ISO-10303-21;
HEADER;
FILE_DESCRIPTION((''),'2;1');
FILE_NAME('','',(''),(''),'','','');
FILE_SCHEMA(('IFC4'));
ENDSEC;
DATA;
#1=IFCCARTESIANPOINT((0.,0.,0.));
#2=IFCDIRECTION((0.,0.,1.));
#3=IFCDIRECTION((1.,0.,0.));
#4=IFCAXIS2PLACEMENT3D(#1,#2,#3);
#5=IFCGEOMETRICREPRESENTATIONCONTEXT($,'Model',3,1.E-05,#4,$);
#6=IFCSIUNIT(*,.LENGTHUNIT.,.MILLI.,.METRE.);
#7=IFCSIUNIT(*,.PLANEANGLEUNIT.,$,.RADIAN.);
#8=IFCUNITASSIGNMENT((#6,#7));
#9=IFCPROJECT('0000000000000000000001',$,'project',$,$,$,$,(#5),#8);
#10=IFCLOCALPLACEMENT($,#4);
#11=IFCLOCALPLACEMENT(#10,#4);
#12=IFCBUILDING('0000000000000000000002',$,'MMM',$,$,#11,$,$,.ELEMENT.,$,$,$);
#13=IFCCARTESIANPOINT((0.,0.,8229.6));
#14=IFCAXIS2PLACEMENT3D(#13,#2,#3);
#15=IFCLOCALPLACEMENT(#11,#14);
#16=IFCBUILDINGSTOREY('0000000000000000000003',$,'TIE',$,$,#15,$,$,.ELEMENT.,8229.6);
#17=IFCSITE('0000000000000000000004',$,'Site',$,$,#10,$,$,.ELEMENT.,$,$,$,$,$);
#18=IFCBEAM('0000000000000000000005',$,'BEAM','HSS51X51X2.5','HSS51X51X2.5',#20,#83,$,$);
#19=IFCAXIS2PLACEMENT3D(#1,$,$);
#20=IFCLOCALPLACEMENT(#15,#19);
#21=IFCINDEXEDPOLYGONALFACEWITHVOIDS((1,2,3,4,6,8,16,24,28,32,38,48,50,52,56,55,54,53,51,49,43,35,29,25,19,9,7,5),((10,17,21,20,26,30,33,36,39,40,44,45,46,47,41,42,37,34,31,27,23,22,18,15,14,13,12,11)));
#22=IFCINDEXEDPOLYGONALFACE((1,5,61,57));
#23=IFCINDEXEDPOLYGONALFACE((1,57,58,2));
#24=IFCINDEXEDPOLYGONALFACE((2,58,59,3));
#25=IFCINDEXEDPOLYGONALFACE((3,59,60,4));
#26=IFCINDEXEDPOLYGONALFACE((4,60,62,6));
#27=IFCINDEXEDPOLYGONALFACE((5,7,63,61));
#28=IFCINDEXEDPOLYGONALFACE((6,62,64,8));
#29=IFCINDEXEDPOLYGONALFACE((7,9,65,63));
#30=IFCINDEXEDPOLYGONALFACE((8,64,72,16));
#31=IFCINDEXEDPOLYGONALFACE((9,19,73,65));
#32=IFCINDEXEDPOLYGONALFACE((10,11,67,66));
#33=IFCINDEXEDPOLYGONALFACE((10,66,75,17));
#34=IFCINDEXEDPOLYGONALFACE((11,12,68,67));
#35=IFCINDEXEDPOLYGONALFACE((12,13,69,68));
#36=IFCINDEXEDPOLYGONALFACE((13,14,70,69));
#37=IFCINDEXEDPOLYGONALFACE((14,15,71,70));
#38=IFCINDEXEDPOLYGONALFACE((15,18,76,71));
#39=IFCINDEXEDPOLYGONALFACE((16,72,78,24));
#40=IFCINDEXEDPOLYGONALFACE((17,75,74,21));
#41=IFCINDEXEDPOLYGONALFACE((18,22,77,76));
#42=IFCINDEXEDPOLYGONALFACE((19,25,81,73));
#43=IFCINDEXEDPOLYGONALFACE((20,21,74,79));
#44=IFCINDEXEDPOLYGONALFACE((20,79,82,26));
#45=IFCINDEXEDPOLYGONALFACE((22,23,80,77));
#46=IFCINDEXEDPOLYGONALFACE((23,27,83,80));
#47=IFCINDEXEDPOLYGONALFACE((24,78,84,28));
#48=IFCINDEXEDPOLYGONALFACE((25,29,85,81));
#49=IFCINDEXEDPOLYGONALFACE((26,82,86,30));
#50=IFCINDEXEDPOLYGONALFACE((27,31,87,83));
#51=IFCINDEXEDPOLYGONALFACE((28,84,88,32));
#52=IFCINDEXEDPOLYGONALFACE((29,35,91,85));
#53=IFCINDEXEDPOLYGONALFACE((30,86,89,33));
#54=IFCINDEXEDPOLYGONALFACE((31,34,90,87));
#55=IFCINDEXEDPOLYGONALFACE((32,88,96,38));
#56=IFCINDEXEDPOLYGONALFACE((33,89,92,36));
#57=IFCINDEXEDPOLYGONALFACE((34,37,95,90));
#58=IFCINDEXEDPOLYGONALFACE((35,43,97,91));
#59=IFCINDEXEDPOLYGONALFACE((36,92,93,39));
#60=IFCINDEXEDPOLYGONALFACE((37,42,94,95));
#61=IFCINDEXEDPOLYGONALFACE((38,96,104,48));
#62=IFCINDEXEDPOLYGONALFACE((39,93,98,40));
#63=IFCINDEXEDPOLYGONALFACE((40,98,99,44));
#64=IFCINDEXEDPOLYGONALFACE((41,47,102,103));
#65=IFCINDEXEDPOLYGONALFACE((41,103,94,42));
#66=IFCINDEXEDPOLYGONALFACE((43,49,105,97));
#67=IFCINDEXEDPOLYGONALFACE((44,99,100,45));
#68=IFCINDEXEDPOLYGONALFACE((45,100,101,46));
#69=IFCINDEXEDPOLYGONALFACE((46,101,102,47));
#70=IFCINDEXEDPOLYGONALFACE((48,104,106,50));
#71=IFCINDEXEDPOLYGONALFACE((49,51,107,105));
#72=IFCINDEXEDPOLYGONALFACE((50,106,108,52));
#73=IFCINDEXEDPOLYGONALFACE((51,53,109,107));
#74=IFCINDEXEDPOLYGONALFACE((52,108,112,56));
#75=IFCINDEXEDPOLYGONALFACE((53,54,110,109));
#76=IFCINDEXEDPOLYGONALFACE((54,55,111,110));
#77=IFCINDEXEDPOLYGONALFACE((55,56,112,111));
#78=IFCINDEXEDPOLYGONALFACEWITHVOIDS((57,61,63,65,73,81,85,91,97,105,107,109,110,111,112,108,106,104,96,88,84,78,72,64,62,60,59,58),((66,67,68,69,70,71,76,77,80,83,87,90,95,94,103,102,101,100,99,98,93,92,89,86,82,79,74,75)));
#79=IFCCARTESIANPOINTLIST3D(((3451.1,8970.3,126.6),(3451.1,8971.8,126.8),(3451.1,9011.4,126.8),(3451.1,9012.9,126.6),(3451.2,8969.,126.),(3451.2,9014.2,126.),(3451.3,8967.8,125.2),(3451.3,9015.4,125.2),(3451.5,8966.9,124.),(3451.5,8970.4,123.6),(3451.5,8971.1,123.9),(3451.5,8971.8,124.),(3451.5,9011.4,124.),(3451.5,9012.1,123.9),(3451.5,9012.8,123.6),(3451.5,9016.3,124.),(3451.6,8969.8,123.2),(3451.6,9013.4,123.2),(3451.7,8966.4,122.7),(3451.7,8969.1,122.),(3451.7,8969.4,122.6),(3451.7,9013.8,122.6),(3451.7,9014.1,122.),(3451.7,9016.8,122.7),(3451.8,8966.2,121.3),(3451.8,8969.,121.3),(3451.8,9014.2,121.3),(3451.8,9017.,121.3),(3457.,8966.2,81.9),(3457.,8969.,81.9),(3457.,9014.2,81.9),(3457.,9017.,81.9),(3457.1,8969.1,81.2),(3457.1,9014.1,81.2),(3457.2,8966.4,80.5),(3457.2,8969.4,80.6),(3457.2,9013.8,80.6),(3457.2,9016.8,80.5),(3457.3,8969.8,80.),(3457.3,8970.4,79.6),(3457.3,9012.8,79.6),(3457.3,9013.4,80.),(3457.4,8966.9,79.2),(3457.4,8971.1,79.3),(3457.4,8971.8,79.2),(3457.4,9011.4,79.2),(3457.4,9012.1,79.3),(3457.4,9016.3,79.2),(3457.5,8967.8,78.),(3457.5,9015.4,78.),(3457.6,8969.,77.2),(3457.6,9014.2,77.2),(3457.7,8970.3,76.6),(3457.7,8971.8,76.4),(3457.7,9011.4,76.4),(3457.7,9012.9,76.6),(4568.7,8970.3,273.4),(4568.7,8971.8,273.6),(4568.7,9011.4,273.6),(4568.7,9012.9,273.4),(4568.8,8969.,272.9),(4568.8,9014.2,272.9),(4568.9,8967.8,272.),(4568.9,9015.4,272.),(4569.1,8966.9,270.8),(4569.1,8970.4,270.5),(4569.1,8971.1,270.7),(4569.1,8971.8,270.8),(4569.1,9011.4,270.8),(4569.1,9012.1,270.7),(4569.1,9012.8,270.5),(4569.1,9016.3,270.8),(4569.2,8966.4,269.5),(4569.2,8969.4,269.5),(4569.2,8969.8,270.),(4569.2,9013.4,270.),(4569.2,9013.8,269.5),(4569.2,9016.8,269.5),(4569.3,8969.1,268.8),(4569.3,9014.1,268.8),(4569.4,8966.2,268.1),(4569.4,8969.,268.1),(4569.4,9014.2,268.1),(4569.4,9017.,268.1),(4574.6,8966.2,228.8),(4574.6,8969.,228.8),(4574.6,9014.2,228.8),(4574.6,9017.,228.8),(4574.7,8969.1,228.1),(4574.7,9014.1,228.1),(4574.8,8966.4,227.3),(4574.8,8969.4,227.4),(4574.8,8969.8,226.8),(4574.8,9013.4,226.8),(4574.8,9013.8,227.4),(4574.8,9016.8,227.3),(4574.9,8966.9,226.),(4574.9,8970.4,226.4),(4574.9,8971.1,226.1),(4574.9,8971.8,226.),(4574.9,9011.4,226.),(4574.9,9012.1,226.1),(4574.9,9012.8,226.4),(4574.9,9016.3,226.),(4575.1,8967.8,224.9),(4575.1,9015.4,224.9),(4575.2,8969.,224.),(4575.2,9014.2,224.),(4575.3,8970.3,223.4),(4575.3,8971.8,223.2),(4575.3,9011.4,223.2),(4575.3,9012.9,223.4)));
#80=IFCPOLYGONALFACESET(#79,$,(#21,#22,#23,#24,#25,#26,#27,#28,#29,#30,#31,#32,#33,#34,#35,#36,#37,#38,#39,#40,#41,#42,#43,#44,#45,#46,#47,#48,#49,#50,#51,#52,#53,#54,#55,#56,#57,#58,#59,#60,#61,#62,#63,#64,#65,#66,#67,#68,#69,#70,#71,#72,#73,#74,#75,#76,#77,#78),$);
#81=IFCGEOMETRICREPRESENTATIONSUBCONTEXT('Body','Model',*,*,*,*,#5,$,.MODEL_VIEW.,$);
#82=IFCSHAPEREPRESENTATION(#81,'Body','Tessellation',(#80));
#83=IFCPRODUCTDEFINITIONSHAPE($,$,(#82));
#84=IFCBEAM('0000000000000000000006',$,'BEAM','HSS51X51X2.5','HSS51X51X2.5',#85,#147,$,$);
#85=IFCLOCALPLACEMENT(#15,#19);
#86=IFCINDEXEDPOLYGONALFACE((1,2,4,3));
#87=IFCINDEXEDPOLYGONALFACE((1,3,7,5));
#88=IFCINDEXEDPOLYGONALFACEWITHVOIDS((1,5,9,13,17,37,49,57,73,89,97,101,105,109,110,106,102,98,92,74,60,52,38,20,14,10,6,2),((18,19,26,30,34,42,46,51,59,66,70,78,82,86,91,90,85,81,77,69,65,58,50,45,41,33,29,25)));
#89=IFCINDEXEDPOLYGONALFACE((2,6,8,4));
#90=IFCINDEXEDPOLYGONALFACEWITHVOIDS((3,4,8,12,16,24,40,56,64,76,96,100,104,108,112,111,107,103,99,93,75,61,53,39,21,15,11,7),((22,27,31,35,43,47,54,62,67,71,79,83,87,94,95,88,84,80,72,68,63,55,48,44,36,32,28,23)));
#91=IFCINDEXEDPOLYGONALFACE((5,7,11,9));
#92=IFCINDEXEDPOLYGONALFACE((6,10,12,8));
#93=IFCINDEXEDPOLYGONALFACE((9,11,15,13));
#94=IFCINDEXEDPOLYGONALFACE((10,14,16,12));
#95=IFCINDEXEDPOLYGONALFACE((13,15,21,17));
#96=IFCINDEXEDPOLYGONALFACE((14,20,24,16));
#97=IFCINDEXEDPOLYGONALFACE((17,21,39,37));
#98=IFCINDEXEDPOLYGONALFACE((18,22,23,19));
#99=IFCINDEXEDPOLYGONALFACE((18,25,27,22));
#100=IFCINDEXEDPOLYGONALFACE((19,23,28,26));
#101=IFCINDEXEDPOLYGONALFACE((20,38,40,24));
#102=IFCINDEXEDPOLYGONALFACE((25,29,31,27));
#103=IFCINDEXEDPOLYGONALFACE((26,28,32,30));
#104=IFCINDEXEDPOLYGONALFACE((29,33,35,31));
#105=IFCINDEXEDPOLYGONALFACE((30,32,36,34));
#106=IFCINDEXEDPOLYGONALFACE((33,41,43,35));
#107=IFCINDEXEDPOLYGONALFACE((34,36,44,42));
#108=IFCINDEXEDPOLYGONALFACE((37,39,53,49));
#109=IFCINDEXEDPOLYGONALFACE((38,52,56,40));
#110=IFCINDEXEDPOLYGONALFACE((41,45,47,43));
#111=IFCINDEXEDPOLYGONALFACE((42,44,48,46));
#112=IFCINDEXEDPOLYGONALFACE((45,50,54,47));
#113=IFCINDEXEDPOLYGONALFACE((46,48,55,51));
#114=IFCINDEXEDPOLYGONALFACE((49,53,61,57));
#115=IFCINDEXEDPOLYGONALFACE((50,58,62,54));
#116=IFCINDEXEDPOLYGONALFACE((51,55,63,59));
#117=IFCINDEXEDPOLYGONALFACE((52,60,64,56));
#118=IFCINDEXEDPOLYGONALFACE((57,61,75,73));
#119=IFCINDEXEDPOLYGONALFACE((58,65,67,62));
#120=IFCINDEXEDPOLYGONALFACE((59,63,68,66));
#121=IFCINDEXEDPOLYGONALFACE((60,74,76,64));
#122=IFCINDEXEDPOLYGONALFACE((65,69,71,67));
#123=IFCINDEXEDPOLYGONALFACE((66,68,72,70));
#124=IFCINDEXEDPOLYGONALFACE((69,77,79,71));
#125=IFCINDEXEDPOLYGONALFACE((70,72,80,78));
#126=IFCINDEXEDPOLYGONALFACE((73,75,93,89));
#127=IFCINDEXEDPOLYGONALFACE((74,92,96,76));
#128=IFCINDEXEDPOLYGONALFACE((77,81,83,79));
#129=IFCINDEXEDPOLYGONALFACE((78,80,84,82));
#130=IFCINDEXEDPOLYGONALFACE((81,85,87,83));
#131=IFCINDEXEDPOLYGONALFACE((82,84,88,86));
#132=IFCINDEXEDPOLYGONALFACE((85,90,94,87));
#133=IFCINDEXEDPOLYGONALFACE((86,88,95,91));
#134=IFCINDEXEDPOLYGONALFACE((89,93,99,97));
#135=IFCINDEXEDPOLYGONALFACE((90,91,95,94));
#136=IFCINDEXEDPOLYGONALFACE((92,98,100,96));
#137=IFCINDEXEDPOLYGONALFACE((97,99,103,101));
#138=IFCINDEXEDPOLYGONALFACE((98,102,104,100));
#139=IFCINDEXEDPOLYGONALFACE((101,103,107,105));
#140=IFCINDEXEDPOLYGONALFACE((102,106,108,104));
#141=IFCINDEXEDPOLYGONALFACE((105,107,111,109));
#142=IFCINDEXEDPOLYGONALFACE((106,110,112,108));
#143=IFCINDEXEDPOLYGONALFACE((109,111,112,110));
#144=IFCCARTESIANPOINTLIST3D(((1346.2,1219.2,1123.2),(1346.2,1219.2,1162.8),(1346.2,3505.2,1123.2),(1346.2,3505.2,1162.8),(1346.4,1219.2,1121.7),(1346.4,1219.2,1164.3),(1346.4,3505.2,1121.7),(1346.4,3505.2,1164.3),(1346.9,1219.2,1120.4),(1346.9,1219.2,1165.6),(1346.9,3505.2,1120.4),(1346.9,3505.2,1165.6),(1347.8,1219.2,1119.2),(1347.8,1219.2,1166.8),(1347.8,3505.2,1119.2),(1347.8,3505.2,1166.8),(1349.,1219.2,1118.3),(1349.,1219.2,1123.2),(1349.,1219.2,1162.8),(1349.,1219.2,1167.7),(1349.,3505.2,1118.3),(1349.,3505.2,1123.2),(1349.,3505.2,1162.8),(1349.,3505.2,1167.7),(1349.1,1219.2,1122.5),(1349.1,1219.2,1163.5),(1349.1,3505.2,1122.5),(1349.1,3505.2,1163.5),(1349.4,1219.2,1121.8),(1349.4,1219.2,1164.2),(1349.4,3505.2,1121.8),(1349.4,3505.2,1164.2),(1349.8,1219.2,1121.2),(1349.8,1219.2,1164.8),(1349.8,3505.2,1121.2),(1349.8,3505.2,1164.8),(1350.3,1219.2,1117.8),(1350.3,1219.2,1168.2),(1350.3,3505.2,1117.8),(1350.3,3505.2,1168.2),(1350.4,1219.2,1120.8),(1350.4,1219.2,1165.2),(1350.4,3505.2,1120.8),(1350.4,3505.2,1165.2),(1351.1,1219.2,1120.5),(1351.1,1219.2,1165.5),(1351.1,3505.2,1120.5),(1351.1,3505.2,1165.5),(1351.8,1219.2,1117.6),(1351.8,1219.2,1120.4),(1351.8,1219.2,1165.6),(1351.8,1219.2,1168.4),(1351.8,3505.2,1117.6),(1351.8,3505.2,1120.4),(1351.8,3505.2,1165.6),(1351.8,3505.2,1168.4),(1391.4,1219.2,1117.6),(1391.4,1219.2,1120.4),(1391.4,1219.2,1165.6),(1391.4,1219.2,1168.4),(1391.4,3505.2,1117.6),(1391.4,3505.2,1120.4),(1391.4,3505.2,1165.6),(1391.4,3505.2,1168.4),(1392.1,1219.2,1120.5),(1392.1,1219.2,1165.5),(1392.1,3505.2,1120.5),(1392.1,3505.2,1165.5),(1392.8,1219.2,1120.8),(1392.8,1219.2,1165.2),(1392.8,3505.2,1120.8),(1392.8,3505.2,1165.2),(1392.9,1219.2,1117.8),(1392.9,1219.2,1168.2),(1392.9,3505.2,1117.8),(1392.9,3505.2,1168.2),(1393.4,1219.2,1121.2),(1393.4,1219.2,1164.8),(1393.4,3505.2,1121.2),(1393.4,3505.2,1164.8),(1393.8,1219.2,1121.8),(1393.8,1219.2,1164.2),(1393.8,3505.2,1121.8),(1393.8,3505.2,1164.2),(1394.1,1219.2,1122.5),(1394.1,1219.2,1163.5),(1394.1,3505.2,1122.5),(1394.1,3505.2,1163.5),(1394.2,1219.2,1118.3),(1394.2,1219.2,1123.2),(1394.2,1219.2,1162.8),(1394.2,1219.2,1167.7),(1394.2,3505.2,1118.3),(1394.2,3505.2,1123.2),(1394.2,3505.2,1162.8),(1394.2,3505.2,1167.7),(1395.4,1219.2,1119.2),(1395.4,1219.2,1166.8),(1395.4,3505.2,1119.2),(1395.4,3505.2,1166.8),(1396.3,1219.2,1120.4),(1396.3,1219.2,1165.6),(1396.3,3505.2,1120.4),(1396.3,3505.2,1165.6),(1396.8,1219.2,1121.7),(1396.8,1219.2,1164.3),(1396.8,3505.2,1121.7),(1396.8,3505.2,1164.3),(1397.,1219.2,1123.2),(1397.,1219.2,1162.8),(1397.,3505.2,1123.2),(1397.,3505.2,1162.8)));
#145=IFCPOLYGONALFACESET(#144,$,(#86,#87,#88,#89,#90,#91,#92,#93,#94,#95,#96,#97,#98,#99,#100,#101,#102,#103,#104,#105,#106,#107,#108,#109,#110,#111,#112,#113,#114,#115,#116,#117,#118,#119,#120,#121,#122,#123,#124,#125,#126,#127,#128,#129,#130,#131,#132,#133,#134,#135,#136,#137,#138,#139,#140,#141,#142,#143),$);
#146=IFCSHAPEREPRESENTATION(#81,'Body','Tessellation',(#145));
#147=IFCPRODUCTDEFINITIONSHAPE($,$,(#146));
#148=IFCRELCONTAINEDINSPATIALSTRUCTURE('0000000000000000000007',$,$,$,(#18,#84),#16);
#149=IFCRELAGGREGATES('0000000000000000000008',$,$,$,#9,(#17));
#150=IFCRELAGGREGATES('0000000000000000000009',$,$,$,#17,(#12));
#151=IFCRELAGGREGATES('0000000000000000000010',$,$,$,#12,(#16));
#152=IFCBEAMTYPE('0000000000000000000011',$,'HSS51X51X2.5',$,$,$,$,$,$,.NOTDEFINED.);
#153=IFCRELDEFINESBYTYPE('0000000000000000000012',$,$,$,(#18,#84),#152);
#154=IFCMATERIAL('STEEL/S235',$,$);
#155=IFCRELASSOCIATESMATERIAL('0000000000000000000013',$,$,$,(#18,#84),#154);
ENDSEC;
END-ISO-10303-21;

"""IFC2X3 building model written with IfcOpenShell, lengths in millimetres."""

from ifc_helpers import new_model, si_unit, frame, origin_with_axes, origin_2d_with_axis, place, context, subcontext, project, spatial, hollow_rectangle, extrude, material, type_object, element, save


model = new_model("IFC2X3")

# Units and contexts
model_context = context("Model", 3, precision=1e-05, world=origin_with_axes())
body_context = subcontext(model_context, "Body", "Model", "MODEL_VIEW")
ifc_project = project(units=[si_unit("LENGTHUNIT", "METRE", prefix="MILLI"), si_unit("PLANEANGLEUNIT", "RADIAN")], contexts=[model_context])

# Site, building, storey
site_placement = place(None, origin_with_axes())
site = spatial("IfcSite", under=ifc_project, at=site_placement, Name="Site", CompositionType="ELEMENT")
building_placement = place(site_placement, origin_with_axes())
building = spatial("IfcBuilding", under=site, at=building_placement, Name="MMM", CompositionType="ELEMENT")
storey_placement = place(building_placement, frame((0.0, 0.0, 8229.6), z_axis=(0.0, 0.0, 1.0), x_axis=(1.0, 0.0, 0.0)))
storey = spatial("IfcBuildingStorey", under=building, at=storey_placement, Name="TIE", CompositionType="ELEMENT", Elevation=8229.6)

# Beams
ifc_material = material(Name="STEEL/S235")
beam_type_1 = type_object("IfcBeamType", Name="HSS51X51X2.5", PredefinedType="NOTDEFINED")
beam_1_placement = place(storey_placement, frame((3454.4, 8991.6, 101.6), z_axis=(-0.130258, 0.0, 0.99148), x_axis=(0.99148, 0.0, 0.130258)))
element("IfcBeam", 1, at=beam_1_placement, inside=storey, type_object=beam_type_1, material=ifc_material, Name="BEAM", Description="HSS51X51X2.5", ObjectType="HSS51X51X2.5", context=body_context, shape_type="SweptSolid", body=[
    extrude(hollow_rectangle(XDim=50.8, YDim=50.8, WallThickness=2.8, InnerFilletRadius=2.8, OuterFilletRadius=5.6, at=origin_2d_with_axis()), frame((1127.2, 0.0, 0.0), z_axis=(-1.0, 0.0, 0.0), x_axis=(0.0, -1.0, 0.0)), (0.0, 0.0, 1.0), 1127.2),
])
beam_2_placement = place(storey_placement, frame((1371.6, 3505.2, 1143.0), z_axis=(0.0, 0.0, 1.0), x_axis=(0.0, -1.0, 0.0)))
element("IfcBeam", 2, at=beam_2_placement, inside=storey, type_object=beam_type_1, material=ifc_material, Name="BEAM", Description="HSS51X51X2.5", ObjectType="HSS51X51X2.5", context=body_context, shape_type="SweptSolid", body=[
    extrude(hollow_rectangle(XDim=50.8, YDim=50.8, WallThickness=2.8, InnerFilletRadius=2.8, OuterFilletRadius=5.6, at=origin_2d_with_axis()), frame((2286.0, 0.0, 0.0), z_axis=(-1.0, 0.0, 0.0), x_axis=(0.0, -1.0, 0.0)), (0.0, 0.0, 1.0), 2286.0),
])

save(model, "model.ifc")
